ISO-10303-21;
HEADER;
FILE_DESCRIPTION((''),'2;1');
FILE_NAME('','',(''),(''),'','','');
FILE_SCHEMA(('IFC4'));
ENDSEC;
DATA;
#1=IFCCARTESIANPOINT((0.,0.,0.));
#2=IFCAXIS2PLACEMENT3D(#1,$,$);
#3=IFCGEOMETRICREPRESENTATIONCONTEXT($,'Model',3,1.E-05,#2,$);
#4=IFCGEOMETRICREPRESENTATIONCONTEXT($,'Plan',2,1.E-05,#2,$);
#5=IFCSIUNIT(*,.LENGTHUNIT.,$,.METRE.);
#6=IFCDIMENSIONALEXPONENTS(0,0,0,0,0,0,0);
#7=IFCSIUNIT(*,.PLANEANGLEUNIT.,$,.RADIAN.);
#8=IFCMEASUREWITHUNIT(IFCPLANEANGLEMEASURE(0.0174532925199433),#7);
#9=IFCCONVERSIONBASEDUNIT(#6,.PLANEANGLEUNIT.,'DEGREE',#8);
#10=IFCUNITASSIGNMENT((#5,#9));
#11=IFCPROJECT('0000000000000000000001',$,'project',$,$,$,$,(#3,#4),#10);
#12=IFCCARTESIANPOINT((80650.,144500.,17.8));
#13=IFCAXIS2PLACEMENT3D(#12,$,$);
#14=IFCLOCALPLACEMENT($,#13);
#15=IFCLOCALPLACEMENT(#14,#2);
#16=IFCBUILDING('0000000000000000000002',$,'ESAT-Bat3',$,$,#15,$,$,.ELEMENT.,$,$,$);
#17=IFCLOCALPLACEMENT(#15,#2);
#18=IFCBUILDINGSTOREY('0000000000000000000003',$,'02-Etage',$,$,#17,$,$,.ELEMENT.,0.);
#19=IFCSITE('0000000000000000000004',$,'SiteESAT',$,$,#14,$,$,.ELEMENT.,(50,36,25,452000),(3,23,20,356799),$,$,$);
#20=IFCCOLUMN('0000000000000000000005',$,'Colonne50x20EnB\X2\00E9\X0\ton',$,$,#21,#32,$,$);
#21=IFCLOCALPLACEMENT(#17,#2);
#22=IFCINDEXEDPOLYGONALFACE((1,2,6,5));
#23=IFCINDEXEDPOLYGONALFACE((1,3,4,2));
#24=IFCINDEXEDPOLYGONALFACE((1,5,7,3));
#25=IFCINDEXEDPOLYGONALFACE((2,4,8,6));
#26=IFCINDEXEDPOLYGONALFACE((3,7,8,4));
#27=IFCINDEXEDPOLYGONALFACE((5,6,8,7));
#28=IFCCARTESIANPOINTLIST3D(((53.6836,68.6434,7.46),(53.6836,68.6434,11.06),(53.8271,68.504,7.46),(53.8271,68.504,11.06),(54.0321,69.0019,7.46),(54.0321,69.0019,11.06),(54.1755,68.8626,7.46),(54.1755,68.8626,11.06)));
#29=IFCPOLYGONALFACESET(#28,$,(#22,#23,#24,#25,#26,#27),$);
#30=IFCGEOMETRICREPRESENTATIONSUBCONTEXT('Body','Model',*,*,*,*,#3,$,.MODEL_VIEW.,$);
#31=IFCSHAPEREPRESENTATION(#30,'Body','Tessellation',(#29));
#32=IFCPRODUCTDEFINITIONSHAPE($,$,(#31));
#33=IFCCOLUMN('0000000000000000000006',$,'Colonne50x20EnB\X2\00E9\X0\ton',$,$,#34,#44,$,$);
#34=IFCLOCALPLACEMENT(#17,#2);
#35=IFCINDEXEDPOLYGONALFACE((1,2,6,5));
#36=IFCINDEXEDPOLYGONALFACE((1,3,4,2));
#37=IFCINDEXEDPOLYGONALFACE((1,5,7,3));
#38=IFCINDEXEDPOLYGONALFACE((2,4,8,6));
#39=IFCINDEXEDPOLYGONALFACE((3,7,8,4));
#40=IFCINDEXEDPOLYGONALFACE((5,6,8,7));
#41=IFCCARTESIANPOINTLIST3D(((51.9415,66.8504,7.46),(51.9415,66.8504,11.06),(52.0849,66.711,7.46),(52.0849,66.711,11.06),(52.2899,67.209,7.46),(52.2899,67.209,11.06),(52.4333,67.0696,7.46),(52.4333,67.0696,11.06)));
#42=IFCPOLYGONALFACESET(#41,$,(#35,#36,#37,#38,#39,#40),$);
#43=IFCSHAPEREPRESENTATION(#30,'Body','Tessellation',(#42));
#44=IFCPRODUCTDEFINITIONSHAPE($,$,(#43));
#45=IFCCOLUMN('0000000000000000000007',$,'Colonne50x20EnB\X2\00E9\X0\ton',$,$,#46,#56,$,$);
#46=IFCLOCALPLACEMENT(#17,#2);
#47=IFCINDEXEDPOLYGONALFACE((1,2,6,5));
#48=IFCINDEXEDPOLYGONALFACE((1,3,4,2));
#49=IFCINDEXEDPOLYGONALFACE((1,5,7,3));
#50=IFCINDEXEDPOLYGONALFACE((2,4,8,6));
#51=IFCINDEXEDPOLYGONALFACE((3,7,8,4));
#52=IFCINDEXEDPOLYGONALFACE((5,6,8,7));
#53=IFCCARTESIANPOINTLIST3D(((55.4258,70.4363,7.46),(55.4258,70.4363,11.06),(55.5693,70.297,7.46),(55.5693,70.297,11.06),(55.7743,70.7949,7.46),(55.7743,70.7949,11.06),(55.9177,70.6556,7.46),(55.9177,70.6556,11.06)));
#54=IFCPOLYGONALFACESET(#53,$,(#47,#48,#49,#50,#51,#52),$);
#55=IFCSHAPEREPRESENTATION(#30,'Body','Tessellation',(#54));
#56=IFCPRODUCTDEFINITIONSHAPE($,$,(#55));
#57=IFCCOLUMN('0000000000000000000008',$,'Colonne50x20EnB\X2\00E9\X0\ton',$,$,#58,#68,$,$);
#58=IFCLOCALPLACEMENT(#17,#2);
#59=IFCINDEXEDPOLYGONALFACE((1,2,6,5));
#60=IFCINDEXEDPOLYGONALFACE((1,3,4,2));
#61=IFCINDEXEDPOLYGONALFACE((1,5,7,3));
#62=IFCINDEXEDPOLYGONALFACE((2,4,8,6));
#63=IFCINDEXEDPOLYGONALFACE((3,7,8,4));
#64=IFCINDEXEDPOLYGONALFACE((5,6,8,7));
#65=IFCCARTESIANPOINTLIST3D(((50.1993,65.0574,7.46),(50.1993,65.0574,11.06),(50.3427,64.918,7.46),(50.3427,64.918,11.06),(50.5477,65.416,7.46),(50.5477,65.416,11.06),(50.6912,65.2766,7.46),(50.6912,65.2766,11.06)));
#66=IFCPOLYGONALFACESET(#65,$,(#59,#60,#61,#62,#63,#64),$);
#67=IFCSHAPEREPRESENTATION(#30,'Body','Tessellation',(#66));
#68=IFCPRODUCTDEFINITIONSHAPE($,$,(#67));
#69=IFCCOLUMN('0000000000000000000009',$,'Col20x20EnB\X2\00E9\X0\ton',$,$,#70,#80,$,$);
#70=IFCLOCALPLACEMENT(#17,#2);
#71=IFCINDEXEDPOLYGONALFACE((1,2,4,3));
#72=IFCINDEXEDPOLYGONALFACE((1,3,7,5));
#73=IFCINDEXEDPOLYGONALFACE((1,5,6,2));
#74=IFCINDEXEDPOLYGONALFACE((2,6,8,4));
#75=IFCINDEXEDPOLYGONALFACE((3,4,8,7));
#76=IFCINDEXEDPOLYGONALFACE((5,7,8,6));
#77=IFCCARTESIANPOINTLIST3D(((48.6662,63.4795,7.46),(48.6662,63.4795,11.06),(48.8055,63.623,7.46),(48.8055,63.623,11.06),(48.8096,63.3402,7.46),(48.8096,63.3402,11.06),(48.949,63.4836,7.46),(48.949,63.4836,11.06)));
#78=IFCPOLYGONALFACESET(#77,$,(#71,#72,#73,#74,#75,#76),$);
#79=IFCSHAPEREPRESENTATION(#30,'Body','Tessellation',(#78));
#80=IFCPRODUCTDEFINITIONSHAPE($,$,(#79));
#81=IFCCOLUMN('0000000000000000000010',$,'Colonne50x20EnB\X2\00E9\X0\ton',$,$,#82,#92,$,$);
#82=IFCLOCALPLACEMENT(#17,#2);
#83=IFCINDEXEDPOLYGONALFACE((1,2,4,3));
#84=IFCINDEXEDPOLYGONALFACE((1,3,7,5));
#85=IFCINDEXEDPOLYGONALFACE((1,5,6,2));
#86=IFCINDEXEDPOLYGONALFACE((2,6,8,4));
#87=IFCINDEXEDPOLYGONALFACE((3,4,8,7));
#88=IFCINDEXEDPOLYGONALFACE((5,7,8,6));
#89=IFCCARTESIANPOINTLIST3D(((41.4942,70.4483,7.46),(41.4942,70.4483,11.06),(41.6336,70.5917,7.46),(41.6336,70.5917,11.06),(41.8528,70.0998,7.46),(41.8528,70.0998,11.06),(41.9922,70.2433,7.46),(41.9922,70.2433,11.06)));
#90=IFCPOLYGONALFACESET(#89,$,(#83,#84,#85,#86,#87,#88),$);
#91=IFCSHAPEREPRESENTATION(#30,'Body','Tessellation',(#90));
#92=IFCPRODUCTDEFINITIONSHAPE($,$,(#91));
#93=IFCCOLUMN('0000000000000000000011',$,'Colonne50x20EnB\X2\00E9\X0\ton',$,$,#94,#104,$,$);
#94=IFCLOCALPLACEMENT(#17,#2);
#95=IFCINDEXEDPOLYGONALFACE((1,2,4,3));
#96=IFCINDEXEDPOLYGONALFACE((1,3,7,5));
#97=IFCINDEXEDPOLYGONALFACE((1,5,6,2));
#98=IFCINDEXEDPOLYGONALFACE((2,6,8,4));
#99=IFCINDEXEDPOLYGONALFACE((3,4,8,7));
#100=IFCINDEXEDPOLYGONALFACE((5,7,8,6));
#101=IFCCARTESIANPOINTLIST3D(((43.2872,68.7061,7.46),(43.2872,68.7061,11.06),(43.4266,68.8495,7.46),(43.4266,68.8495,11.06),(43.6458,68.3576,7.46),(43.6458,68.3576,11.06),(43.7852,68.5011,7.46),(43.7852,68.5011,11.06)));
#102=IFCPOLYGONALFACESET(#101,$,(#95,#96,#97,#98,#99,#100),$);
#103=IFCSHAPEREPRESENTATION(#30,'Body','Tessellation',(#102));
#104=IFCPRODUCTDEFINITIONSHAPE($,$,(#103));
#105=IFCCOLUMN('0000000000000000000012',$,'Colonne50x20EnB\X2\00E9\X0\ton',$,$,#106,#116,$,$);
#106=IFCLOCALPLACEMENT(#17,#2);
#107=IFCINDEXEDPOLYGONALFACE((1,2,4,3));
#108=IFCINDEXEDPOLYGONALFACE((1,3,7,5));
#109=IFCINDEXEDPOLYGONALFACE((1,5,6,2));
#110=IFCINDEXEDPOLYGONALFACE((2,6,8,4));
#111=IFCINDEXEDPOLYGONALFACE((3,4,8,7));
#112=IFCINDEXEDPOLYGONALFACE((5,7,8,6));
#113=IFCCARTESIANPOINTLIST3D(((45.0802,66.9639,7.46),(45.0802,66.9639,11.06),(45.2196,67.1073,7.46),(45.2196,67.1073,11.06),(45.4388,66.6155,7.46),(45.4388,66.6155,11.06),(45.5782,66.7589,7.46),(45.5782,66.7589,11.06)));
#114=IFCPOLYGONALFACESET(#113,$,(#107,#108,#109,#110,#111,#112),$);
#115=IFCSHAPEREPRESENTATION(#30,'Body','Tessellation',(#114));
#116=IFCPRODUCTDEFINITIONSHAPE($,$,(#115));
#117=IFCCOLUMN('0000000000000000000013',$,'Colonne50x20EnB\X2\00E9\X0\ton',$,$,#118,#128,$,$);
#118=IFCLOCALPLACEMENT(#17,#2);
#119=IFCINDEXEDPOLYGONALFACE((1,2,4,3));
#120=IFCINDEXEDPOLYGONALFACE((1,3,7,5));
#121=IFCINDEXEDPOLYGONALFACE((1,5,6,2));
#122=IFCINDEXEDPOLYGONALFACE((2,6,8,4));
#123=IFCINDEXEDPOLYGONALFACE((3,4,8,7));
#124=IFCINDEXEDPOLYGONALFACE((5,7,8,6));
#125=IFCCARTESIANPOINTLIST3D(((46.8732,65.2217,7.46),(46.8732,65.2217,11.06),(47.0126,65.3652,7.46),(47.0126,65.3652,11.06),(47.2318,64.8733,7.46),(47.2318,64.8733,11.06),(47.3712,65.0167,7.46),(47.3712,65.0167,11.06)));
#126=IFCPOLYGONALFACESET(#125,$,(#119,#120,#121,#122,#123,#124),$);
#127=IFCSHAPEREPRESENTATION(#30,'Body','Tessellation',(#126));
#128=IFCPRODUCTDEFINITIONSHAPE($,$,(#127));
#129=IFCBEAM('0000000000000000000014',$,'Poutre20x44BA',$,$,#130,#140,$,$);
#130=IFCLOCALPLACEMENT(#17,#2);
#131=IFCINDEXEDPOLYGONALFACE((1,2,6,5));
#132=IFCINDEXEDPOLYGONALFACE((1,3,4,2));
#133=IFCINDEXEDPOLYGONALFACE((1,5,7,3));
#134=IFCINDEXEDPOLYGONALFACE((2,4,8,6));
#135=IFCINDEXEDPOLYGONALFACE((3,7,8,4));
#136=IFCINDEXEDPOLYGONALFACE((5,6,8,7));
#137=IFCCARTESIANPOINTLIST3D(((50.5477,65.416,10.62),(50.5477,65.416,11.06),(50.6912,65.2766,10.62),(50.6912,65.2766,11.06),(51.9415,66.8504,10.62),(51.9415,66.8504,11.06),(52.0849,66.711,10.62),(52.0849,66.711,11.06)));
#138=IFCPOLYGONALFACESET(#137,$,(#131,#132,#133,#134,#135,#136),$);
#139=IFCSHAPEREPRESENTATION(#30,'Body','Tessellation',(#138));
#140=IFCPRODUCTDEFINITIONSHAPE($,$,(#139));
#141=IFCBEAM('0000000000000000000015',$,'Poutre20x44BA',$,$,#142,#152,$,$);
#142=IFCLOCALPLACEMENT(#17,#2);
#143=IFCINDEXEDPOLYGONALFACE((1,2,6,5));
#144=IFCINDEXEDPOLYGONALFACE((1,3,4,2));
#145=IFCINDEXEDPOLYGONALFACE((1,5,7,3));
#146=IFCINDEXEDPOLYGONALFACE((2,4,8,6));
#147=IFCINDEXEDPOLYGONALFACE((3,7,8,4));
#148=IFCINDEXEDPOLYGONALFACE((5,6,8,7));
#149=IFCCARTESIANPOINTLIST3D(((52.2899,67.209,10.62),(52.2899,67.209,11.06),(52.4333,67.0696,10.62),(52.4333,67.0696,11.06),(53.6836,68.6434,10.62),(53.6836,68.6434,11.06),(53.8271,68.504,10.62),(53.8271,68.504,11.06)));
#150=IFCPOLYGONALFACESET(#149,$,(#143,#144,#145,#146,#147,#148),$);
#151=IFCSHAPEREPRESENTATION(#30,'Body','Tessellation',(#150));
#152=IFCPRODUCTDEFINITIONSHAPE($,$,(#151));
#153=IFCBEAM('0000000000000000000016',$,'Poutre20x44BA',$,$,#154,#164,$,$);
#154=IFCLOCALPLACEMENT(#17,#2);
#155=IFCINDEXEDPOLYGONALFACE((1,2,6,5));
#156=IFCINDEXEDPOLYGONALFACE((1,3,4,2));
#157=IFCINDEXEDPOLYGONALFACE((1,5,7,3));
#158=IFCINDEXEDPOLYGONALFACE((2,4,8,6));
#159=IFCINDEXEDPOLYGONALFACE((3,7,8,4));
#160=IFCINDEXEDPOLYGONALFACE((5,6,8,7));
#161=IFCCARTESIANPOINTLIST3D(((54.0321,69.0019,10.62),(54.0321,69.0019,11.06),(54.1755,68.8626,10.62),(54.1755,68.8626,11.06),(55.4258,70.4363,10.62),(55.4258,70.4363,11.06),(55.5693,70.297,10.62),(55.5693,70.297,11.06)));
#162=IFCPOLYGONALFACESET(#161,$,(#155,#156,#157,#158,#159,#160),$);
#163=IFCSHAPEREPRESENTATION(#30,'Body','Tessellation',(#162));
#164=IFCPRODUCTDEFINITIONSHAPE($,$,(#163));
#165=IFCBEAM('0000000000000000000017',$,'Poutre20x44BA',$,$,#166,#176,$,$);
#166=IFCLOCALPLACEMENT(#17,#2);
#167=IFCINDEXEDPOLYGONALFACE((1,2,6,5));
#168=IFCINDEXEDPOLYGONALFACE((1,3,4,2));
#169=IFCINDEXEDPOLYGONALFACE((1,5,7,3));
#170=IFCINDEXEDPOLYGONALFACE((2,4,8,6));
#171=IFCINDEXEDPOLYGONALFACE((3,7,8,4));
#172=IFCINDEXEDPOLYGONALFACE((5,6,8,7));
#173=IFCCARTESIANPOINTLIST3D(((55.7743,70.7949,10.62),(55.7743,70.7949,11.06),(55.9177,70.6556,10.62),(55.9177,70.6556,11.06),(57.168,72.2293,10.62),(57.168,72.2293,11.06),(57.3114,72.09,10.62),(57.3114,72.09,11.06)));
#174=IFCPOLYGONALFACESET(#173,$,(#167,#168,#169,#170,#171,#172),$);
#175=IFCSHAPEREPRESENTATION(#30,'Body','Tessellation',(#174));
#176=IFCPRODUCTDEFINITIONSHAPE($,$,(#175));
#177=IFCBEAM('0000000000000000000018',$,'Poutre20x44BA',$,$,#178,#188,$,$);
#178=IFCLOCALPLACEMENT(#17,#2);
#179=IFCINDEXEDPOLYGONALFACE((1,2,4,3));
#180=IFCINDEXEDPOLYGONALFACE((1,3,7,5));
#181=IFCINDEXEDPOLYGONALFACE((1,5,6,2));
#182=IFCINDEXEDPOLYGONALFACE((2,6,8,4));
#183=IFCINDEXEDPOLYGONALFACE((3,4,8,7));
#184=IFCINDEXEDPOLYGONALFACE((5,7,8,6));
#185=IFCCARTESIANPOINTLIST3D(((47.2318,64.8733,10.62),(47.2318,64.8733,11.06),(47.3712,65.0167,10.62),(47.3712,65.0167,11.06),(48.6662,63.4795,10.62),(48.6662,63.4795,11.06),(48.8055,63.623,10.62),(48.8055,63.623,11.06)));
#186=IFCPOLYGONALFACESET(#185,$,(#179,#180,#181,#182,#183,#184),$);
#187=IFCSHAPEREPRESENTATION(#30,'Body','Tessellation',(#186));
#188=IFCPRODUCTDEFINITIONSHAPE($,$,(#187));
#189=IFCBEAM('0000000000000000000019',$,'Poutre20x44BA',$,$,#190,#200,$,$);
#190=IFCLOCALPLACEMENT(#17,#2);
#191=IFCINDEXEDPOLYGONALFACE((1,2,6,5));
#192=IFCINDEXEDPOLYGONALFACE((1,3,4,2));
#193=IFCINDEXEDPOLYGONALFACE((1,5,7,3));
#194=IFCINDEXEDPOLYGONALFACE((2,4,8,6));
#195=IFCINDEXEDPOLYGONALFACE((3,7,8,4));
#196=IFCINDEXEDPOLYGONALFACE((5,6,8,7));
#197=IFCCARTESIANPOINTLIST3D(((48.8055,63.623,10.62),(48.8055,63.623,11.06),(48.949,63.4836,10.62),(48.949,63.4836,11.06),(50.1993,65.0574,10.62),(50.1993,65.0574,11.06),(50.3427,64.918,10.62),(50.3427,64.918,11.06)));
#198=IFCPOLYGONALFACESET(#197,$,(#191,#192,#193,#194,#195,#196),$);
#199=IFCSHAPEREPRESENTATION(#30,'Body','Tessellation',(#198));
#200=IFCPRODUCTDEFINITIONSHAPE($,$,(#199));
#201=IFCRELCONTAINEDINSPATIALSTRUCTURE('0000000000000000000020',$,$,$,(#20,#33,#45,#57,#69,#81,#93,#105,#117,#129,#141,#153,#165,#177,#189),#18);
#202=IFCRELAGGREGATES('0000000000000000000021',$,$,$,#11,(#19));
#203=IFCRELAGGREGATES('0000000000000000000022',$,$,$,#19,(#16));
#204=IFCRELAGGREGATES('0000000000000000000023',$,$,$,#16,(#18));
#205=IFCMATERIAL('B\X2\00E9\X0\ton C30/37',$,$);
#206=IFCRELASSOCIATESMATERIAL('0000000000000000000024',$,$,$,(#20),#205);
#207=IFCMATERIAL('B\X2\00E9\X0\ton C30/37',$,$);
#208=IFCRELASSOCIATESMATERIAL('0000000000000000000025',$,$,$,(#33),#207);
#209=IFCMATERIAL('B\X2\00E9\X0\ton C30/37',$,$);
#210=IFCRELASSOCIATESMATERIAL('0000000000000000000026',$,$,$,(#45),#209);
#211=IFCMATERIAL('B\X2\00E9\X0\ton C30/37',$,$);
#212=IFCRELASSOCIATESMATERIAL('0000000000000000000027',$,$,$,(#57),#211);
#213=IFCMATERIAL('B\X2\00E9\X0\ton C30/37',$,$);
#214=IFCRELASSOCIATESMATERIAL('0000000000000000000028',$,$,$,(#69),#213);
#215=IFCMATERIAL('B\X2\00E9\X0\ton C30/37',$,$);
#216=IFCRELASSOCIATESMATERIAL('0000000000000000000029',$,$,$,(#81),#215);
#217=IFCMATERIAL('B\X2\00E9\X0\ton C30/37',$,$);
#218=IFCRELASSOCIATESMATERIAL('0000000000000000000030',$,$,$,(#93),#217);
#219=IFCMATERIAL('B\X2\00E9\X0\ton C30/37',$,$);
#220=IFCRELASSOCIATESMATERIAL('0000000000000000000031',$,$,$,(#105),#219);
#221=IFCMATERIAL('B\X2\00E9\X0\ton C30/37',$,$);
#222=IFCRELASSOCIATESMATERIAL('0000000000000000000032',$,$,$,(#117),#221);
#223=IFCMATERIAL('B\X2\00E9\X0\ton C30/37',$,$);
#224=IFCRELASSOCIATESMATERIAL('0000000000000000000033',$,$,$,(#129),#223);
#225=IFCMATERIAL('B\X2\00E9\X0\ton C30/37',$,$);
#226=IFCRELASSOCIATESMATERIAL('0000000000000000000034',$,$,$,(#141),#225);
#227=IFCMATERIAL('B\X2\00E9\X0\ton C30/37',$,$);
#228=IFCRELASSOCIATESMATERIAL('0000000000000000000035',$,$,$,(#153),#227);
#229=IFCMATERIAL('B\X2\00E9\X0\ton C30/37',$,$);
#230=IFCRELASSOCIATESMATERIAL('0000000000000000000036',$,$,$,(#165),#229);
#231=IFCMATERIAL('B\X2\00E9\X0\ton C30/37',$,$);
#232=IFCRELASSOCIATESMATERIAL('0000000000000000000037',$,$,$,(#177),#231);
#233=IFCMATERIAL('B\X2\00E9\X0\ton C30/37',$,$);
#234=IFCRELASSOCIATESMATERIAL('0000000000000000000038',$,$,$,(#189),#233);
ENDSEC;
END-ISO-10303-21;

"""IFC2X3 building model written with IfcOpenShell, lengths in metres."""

from ifc_helpers import new_model, entity, si_unit, converted_unit, frame, frame_2d, origin, origin_with_axes, place, context, subcontext, project, spatial, rectangle, extrude, material, element, save


model = new_model("IFC2X3")

# Units and contexts
model_context = context("Model", 3, precision=1e-05, world=origin())
plan_context = context("Plan", 2, precision=1e-05, world=origin())
body_context = subcontext(model_context, "Body", "Model", "MODEL_VIEW")
ifc_project = project(units=[si_unit("LENGTHUNIT", "METRE"), converted_unit("PLANEANGLEUNIT", "DEGREE", entity("IfcPlaneAngleMeasure", 0.0174532925199433), si_unit("PLANEANGLEUNIT", "RADIAN"), dimensions=[0, 0, 0, 0, 0, 0, 0])], contexts=[model_context, plan_context])

# Site, building, storey
site_placement = place(None, frame((80650.0, 144500.0, 17.8)))
site = spatial("IfcSite", under=ifc_project, at=site_placement, Name="SiteESAT", CompositionType="ELEMENT", RefLatitude=(50, 36, 25, 452000), RefLongitude=(3, 23, 20, 356799))
building_placement = place(site_placement, origin())
building = spatial("IfcBuilding", under=site, at=building_placement, Name="ESAT-Bat3", CompositionType="ELEMENT")
storey_placement = place(building_placement, origin())
storey = spatial("IfcBuildingStorey", under=building, at=storey_placement, Name="02-Etage", CompositionType="ELEMENT", Elevation=0.0)

# Columns
ifc_material_1 = material(Name="Béton C30/37")
column_1_placement = place(storey_placement, frame((53.8271, 68.504, 7.46)))
element("IfcColumn", 1, at=column_1_placement, inside=storey, material=ifc_material_1, Name="Colonne50x20EnBéton", context=body_context, shape_type="SweptSolid", body=[
    extrude(rectangle(XDim=0.5, YDim=0.2, at=frame_2d((0.1025, 0.249), x_axis=(0.696872, 0.717196))), origin_with_axes(), (0.0, 0.0, 1.0), 3.6),
])
ifc_material_2 = material(Name="Béton C30/37")
column_2_placement = place(storey_placement, frame((52.0849, 66.711, 7.46)))
element("IfcColumn", 2, at=column_2_placement, inside=storey, material=ifc_material_2, Name="Colonne50x20EnBéton", context=body_context, shape_type="SweptSolid", body=[
    extrude(rectangle(XDim=0.5, YDim=0.2, at=frame_2d((0.1025, 0.249), x_axis=(0.696872, 0.717196))), origin_with_axes(), (0.0, 0.0, 1.0), 3.6),
])
ifc_material_3 = material(Name="Béton C30/37")
column_3_placement = place(storey_placement, frame((55.5693, 70.297, 7.46)))
element("IfcColumn", 3, at=column_3_placement, inside=storey, material=ifc_material_3, Name="Colonne50x20EnBéton", context=body_context, shape_type="SweptSolid", body=[
    extrude(rectangle(XDim=0.5, YDim=0.2, at=frame_2d((0.1025, 0.249), x_axis=(0.696872, 0.717196))), origin_with_axes(), (0.0, 0.0, 1.0), 3.6),
])
ifc_material_4 = material(Name="Béton C30/37")
column_4_placement = place(storey_placement, frame((50.3427, 64.918, 7.46)))
element("IfcColumn", 4, at=column_4_placement, inside=storey, material=ifc_material_4, Name="Colonne50x20EnBéton", context=body_context, shape_type="SweptSolid", body=[
    extrude(rectangle(XDim=0.5, YDim=0.2, at=frame_2d((0.1025, 0.249), x_axis=(0.696872, 0.717196))), origin_with_axes(), (0.0, 0.0, 1.0), 3.6),
])
ifc_material_5 = material(Name="Béton C30/37")
column_5_placement = place(storey_placement, frame((48.8096, 63.3402, 7.46)))
element("IfcColumn", 5, at=column_5_placement, inside=storey, material=ifc_material_5, Name="Col20x20EnBéton", context=body_context, shape_type="SweptSolid", body=[
    extrude(rectangle(XDim=0.2, YDim=0.2, at=frame_2d((-0.002, 0.1414), x_axis=(0.696872, 0.717196))), origin_with_axes(), (0.0, 0.0, 1.0), 3.6),
])
ifc_material_6 = material(Name="Béton C30/37")
column_6_placement = place(storey_placement, frame((41.9922, 70.2433, 7.46)))
element("IfcColumn", 6, at=column_6_placement, inside=storey, material=ifc_material_6, Name="Colonne50x20EnBéton", context=body_context, shape_type="SweptSolid", body=[
    extrude(rectangle(XDim=0.5, YDim=0.2, at=frame_2d((-0.249, 0.1025), x_axis=(-0.717196, 0.696872))), origin_with_axes(), (0.0, 0.0, 1.0), 3.6),
])
ifc_material_7 = material(Name="Béton C30/37")
column_7_placement = place(storey_placement, frame((43.7852, 68.5011, 7.46)))
element("IfcColumn", 7, at=column_7_placement, inside=storey, material=ifc_material_7, Name="Colonne50x20EnBéton", context=body_context, shape_type="SweptSolid", body=[
    extrude(rectangle(XDim=0.5, YDim=0.2, at=frame_2d((-0.249, 0.1025), x_axis=(-0.717196, 0.696872))), origin_with_axes(), (0.0, 0.0, 1.0), 3.6),
])
ifc_material_8 = material(Name="Béton C30/37")
column_8_placement = place(storey_placement, frame((45.5782, 66.7589, 7.46)))
element("IfcColumn", 8, at=column_8_placement, inside=storey, material=ifc_material_8, Name="Colonne50x20EnBéton", context=body_context, shape_type="SweptSolid", body=[
    extrude(rectangle(XDim=0.5, YDim=0.2, at=frame_2d((-0.249, 0.1025), x_axis=(-0.717196, 0.696872))), origin_with_axes(), (0.0, 0.0, 1.0), 3.6),
])
ifc_material_9 = material(Name="Béton C30/37")
column_9_placement = place(storey_placement, frame((47.3712, 65.0167, 7.46)))
element("IfcColumn", 9, at=column_9_placement, inside=storey, material=ifc_material_9, Name="Colonne50x20EnBéton", context=body_context, shape_type="SweptSolid", body=[
    extrude(rectangle(XDim=0.5, YDim=0.2, at=frame_2d((-0.249, 0.1025), x_axis=(-0.717196, 0.696872))), origin_with_axes(), (0.0, 0.0, 1.0), 3.6),
])

# Beams
ifc_material_10 = material(Name="Béton C30/37")
beam_1_placement = place(storey_placement, frame((50.6912, 65.2766, 10.62), z_axis=(0.0, 0.0, 1.0), x_axis=(0.696872, 0.717196, 0.0)))
element("IfcBeam", 10, at=beam_1_placement, inside=storey, material=ifc_material_10, Name="Poutre20x44BA", context=body_context, shape_type="SweptSolid", body=[
    extrude(rectangle(XDim=0.2, YDim=0.44, at=frame_2d((0.1, 0.22), x_axis=(1.0, 0.0))), frame((0.0, 0.0, 0.0), z_axis=(1.0, 0.0, 0.0), x_axis=(0.0, 1.0, 0.0)), (0.0, 0.0, 1.0), 2.0),
])
ifc_material_11 = material(Name="Béton C30/37")
beam_2_placement = place(storey_placement, frame((52.4333, 67.0696, 10.62), z_axis=(0.0, 0.0, 1.0), x_axis=(0.696872, 0.717196, 0.0)))
element("IfcBeam", 11, at=beam_2_placement, inside=storey, material=ifc_material_11, Name="Poutre20x44BA", context=body_context, shape_type="SweptSolid", body=[
    extrude(rectangle(XDim=0.2, YDim=0.44, at=frame_2d((0.1, 0.22), x_axis=(1.0, 0.0))), frame((0.0, 0.0, 0.0), z_axis=(1.0, 0.0, 0.0), x_axis=(0.0, 1.0, 0.0)), (0.0, 0.0, 1.0), 2.0),
])
ifc_material_12 = material(Name="Béton C30/37")
beam_3_placement = place(storey_placement, frame((54.1755, 68.8626, 10.62), z_axis=(0.0, 0.0, 1.0), x_axis=(0.696872, 0.717196, 0.0)))
element("IfcBeam", 12, at=beam_3_placement, inside=storey, material=ifc_material_12, Name="Poutre20x44BA", context=body_context, shape_type="SweptSolid", body=[
    extrude(rectangle(XDim=0.2, YDim=0.44, at=frame_2d((0.1, 0.22), x_axis=(1.0, 0.0))), frame((0.0, 0.0, 0.0), z_axis=(1.0, 0.0, 0.0), x_axis=(0.0, 1.0, 0.0)), (0.0, 0.0, 1.0), 2.0),
])
ifc_material_13 = material(Name="Béton C30/37")
beam_4_placement = place(storey_placement, frame((55.9177, 70.6556, 10.62), z_axis=(0.0, 0.0, 1.0), x_axis=(0.696872, 0.717196, 0.0)))
element("IfcBeam", 13, at=beam_4_placement, inside=storey, material=ifc_material_13, Name="Poutre20x44BA", context=body_context, shape_type="SweptSolid", body=[
    extrude(rectangle(XDim=0.2, YDim=0.44, at=frame_2d((0.1, 0.22), x_axis=(1.0, 0.0))), frame((0.0, 0.0, 0.0), z_axis=(1.0, 0.0, 0.0), x_axis=(0.0, 1.0, 0.0)), (0.0, 0.0, 1.0), 2.0),
])
ifc_material_14 = material(Name="Béton C30/37")
beam_5_placement = place(storey_placement, frame((48.8055, 63.623, 10.62), z_axis=(0.0, 0.0, 1.0), x_axis=(-0.717196, 0.696872, 0.0)))
element("IfcBeam", 14, at=beam_5_placement, inside=storey, material=ifc_material_14, Name="Poutre20x44BA", context=body_context, shape_type="SweptSolid", body=[
    extrude(rectangle(XDim=0.2, YDim=0.44, at=frame_2d((0.1, 0.22), x_axis=(1.0, 0.0))), frame((0.0, 0.0, 0.0), z_axis=(1.0, 0.0, 0.0), x_axis=(0.0, 1.0, 0.0)), (0.0, 0.0, 1.0), 2.0),
])
ifc_material_15 = material(Name="Béton C30/37")
beam_6_placement = place(storey_placement, frame((48.949, 63.4836, 10.62), z_axis=(0.0, 0.0, 1.0), x_axis=(0.696872, 0.717196, 0.0)))
element("IfcBeam", 15, at=beam_6_placement, inside=storey, material=ifc_material_15, Name="Poutre20x44BA", context=body_context, shape_type="SweptSolid", body=[
    extrude(rectangle(XDim=0.2, YDim=0.44, at=frame_2d((0.1, 0.22), x_axis=(1.0, 0.0))), frame((0.0, 0.0, 0.0), z_axis=(1.0, 0.0, 0.0), x_axis=(0.0, 1.0, 0.0)), (0.0, 0.0, 1.0), 2.0),
])

save(model, "model.ifc")
